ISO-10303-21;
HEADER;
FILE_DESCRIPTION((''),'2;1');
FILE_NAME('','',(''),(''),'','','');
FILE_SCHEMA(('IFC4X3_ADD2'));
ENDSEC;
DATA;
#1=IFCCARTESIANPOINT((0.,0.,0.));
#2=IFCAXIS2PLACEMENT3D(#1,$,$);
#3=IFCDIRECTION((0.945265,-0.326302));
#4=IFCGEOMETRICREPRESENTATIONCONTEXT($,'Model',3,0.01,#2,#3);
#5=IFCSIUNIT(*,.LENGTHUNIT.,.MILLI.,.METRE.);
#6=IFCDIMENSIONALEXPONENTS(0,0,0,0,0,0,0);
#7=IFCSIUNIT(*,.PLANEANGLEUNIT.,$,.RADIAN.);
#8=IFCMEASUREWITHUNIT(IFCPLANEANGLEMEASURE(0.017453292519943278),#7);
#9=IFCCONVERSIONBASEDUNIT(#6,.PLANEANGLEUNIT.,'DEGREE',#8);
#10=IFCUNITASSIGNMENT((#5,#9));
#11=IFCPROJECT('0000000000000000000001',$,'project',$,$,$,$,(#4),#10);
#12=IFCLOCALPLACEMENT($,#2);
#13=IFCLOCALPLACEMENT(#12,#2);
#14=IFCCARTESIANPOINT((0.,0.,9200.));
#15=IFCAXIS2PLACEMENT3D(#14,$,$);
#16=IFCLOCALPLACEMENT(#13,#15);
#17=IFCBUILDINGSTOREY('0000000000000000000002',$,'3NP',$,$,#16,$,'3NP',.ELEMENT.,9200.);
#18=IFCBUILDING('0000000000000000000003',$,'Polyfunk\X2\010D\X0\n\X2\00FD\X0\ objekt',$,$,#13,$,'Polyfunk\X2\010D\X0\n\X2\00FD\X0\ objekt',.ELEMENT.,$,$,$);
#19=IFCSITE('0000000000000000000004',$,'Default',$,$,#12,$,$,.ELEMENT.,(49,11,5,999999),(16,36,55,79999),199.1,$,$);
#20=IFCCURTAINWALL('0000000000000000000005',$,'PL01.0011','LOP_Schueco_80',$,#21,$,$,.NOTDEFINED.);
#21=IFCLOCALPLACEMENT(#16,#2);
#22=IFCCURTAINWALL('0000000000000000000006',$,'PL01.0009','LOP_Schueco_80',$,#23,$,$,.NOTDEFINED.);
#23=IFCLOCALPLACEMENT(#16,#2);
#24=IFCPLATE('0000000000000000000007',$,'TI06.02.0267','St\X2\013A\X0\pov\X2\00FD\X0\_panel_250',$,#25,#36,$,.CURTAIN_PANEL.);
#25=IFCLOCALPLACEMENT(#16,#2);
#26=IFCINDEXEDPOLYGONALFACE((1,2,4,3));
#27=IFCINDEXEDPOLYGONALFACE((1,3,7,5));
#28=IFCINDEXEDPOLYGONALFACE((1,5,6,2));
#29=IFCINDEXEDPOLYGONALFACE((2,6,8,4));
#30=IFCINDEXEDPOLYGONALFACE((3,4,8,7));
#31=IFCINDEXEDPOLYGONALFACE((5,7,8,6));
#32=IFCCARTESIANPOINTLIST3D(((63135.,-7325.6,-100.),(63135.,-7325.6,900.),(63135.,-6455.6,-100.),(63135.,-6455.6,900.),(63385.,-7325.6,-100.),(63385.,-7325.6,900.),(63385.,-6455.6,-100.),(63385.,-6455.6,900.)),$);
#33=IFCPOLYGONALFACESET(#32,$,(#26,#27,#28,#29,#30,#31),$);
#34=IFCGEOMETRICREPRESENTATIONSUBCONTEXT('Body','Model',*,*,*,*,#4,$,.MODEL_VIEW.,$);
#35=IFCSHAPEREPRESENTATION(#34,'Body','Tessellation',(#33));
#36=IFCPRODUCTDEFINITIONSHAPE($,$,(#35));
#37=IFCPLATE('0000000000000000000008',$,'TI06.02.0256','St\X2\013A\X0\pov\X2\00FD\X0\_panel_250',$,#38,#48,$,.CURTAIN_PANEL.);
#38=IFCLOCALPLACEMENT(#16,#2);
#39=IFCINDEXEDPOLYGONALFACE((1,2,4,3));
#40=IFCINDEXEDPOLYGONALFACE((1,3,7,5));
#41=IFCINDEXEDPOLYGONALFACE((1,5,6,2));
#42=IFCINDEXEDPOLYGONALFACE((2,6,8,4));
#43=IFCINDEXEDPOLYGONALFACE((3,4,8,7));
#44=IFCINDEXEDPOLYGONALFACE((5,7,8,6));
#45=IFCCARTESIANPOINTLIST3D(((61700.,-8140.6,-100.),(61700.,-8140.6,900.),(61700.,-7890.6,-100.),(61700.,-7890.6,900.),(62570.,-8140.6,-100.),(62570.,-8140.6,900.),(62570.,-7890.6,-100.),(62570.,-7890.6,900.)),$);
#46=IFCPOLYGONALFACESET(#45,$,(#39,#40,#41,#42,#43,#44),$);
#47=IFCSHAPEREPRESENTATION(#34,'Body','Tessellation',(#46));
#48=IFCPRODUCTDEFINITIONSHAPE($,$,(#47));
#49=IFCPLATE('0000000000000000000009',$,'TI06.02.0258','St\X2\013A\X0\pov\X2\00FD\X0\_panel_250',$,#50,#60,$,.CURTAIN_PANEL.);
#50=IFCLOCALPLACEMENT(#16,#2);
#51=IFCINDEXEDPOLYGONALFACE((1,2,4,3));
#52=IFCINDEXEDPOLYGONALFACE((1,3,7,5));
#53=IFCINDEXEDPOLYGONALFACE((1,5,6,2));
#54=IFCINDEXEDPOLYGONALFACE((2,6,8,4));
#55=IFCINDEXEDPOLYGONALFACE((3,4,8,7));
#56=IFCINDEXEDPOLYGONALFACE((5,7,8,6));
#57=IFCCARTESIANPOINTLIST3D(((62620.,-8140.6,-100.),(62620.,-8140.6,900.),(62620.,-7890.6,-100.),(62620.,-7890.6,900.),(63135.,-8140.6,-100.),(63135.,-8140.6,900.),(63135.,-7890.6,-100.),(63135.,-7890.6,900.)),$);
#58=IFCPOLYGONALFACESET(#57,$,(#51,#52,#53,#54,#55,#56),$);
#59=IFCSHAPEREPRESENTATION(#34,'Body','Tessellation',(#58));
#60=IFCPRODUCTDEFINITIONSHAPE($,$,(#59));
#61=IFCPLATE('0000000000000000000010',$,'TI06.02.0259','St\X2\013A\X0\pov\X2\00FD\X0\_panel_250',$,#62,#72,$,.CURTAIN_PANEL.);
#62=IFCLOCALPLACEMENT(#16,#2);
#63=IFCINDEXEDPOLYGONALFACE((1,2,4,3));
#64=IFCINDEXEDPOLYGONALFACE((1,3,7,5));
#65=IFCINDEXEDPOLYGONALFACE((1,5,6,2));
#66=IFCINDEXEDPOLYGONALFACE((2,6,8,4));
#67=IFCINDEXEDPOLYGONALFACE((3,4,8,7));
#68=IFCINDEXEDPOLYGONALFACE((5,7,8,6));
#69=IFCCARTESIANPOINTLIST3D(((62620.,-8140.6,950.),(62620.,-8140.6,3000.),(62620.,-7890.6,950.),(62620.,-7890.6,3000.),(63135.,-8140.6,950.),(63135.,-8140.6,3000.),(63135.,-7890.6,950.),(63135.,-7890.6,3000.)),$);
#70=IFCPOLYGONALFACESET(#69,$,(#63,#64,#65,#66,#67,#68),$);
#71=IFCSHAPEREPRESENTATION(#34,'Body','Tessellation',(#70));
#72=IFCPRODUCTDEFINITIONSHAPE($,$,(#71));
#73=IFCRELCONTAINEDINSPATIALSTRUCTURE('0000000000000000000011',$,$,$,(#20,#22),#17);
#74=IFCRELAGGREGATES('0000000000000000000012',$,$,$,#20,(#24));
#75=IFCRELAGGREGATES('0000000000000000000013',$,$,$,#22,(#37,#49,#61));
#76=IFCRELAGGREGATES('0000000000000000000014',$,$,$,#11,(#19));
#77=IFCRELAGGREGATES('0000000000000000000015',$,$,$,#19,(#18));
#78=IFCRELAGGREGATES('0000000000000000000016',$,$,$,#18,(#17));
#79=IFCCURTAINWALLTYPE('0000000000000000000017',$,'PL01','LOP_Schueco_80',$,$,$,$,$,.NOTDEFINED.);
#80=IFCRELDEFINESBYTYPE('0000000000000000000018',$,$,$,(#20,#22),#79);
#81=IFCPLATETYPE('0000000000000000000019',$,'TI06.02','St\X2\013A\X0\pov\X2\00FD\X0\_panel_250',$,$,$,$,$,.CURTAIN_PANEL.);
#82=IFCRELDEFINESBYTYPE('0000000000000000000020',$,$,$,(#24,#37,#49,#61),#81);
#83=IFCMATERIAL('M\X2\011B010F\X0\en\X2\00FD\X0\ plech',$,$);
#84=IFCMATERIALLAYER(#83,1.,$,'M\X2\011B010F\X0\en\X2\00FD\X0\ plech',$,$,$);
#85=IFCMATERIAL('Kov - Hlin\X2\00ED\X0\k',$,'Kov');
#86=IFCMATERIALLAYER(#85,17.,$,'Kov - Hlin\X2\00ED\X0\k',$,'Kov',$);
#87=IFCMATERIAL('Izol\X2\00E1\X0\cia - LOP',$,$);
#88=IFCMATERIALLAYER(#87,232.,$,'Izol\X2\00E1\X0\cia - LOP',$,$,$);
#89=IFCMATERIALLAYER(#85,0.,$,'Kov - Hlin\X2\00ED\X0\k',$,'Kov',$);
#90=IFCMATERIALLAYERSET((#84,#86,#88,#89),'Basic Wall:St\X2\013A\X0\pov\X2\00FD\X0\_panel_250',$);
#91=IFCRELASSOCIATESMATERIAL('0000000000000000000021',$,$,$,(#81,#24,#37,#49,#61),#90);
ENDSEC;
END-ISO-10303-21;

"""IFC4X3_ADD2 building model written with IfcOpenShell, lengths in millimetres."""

from ifc_helpers import new_model, entity, si_unit, converted_unit, direction, frame, frame_2d, origin, place, context, subcontext, project, spatial, rectangle, extrude, material, layer, layer_set, layer_usage, type_object, element, aggregate, save


model = new_model("IFC4X3_ADD2")

# Units and contexts
model_context = context("Model", 3, precision=0.01, world=origin(), true_north=direction((0.945265, -0.326302)))
body_context = subcontext(model_context, "Body", "Model", "MODEL_VIEW")
ifc_project = project(units=[si_unit("LENGTHUNIT", "METRE", prefix="MILLI"), converted_unit("PLANEANGLEUNIT", "DEGREE", entity("IfcPlaneAngleMeasure", 0.017453292519943278), si_unit("PLANEANGLEUNIT", "RADIAN"), dimensions=[0, 0, 0, 0, 0, 0, 0])], contexts=[model_context])

# Site, building, storey
site_placement = place(None, origin())
site = spatial("IfcSite", under=ifc_project, at=site_placement, Name="Default", CompositionType="ELEMENT", RefLatitude=(49, 11, 5, 999999), RefLongitude=(16, 36, 55, 79999), RefElevation=199.1)
building_placement = place(site_placement, origin())
building = spatial("IfcBuilding", under=site, at=building_placement, Name="Polyfunkčný objekt", LongName="Polyfunkčný objekt", CompositionType="ELEMENT")
storey_placement = place(building_placement, frame((0.0, 0.0, 9200.0)))
storey = spatial("IfcBuildingStorey", under=building, at=storey_placement, Name="3NP", LongName="3NP", CompositionType="ELEMENT", Elevation=9200.0)

# Curtain walls
curtain_wall_type = type_object("IfcCurtainWallType", Name="PL01", Description="LOP_Schueco_80", PredefinedType="NOTDEFINED")
curtain_wall_1_placement = place(storey_placement, frame((0.0, 0.0, -9200.0)))
curtain_wall_1 = element("IfcCurtainWall", 1, at=curtain_wall_1_placement, inside=storey, type_object=curtain_wall_type, Name="PL01.0011", Description="LOP_Schueco_80", PredefinedType="NOTDEFINED")
curtain_wall_2_placement = place(storey_placement, frame((0.0, 0.0, -9200.0)))
curtain_wall_2 = element("IfcCurtainWall", 2, at=curtain_wall_2_placement, inside=storey, type_object=curtain_wall_type, Name="PL01.0009", Description="LOP_Schueco_80", PredefinedType="NOTDEFINED")

# Plates
ifc_material_1 = material(Name="Měďený plech")
ifc_layer_1 = layer(ifc_material_1, 1.0, Name="Měďený plech")
ifc_material_2 = material(Name="Kov - Hliník", Category="Kov")
ifc_layer_2 = layer(ifc_material_2, 17.0, Name="Kov - Hliník", Category="Kov")
ifc_material_3 = material(Name="Izolácia - LOP")
ifc_layer_3 = layer(ifc_material_3, 232.0, Name="Izolácia - LOP")
ifc_layer_4 = layer(ifc_material_2, 0.0, Name="Kov - Hliník", Category="Kov")
ifc_layer_set = layer_set([ifc_layer_1, ifc_layer_2, ifc_layer_3, ifc_layer_4], Name="Basic Wall:Stĺpový_panel_250")
ifc_layer_usage_1 = layer_usage(ifc_layer_set, "AXIS2", "NEGATIVE", 125.0)
plate_type = type_object("IfcPlateType", Name="TI06.02", Description="Stĺpový_panel_250", PredefinedType="CURTAIN_PANEL", material=ifc_layer_set)
plate_1_placement = place(storey_placement, frame((63260.0, -6455.6, -100.0), z_axis=(0.0, 0.0, 1.0), x_axis=(0.0, -1.0, 0.0)))
plate_1 = element("IfcPlate", 3, at=plate_1_placement, type_object=plate_type, material=ifc_layer_usage_1, Name="TI06.02.0267", Description="Stĺpový_panel_250", PredefinedType="CURTAIN_PANEL", context=body_context, shape_type="SweptSolid", body=[
    extrude(rectangle(XDim=250.0, YDim=870.0, at=frame_2d((0.0, 0.0), x_axis=(1.0, 0.0))), frame((435.0, 0.0, 0.0), z_axis=(0.0, 0.0, 1.0), x_axis=(0.0, 1.0, 0.0)), (0.0, 0.0, 1.0), 1000.0),
])
aggregate(curtain_wall_1, [plate_1])
ifc_layer_usage_2 = layer_usage(ifc_layer_set, "AXIS2", "POSITIVE", -125.0)
plate_2_placement = place(storey_placement, frame((61700.0, -8015.6, -100.0)))
plate_2 = element("IfcPlate", 4, at=plate_2_placement, type_object=plate_type, material=ifc_layer_usage_2, Name="TI06.02.0256", Description="Stĺpový_panel_250", PredefinedType="CURTAIN_PANEL", context=body_context, shape_type="SweptSolid", body=[
    extrude(rectangle(XDim=250.0, YDim=870.0, at=frame_2d((0.0, 0.0), x_axis=(1.0, 0.0))), frame((435.0, 0.0, 0.0), z_axis=(0.0, 0.0, 1.0), x_axis=(0.0, 1.0, 0.0)), (0.0, 0.0, 1.0), 1000.0),
])
ifc_layer_usage_3 = layer_usage(ifc_layer_set, "AXIS2", "POSITIVE", -125.0)
plate_3_placement = place(storey_placement, frame((62620.0, -8015.6, -100.0)))
plate_3 = element("IfcPlate", 5, at=plate_3_placement, type_object=plate_type, material=ifc_layer_usage_3, Name="TI06.02.0258", Description="Stĺpový_panel_250", PredefinedType="CURTAIN_PANEL", context=body_context, shape_type="SweptSolid", body=[
    extrude(rectangle(XDim=250.0, YDim=515.0, at=frame_2d((0.0, 0.0), x_axis=(1.0, 0.0))), frame((257.5, 0.0, 0.0), z_axis=(0.0, 0.0, 1.0), x_axis=(0.0, 1.0, 0.0)), (0.0, 0.0, 1.0), 1000.0),
])
ifc_layer_usage_4 = layer_usage(ifc_layer_set, "AXIS2", "POSITIVE", -125.0)
plate_4_placement = place(storey_placement, frame((62620.0, -8015.6, 950.0)))
plate_4 = element("IfcPlate", 6, at=plate_4_placement, type_object=plate_type, material=ifc_layer_usage_4, Name="TI06.02.0259", Description="Stĺpový_panel_250", PredefinedType="CURTAIN_PANEL", context=body_context, shape_type="SweptSolid", body=[
    extrude(rectangle(XDim=250.0, YDim=515.0, at=frame_2d((0.0, 0.0), x_axis=(1.0, 0.0))), frame((257.5, 0.0, 0.0), z_axis=(0.0, 0.0, 1.0), x_axis=(0.0, 1.0, 0.0)), (0.0, 0.0, 1.0), 2050.0),
])
aggregate(curtain_wall_2, [plate_2, plate_3, plate_4])

save(model, "model.ifc")
